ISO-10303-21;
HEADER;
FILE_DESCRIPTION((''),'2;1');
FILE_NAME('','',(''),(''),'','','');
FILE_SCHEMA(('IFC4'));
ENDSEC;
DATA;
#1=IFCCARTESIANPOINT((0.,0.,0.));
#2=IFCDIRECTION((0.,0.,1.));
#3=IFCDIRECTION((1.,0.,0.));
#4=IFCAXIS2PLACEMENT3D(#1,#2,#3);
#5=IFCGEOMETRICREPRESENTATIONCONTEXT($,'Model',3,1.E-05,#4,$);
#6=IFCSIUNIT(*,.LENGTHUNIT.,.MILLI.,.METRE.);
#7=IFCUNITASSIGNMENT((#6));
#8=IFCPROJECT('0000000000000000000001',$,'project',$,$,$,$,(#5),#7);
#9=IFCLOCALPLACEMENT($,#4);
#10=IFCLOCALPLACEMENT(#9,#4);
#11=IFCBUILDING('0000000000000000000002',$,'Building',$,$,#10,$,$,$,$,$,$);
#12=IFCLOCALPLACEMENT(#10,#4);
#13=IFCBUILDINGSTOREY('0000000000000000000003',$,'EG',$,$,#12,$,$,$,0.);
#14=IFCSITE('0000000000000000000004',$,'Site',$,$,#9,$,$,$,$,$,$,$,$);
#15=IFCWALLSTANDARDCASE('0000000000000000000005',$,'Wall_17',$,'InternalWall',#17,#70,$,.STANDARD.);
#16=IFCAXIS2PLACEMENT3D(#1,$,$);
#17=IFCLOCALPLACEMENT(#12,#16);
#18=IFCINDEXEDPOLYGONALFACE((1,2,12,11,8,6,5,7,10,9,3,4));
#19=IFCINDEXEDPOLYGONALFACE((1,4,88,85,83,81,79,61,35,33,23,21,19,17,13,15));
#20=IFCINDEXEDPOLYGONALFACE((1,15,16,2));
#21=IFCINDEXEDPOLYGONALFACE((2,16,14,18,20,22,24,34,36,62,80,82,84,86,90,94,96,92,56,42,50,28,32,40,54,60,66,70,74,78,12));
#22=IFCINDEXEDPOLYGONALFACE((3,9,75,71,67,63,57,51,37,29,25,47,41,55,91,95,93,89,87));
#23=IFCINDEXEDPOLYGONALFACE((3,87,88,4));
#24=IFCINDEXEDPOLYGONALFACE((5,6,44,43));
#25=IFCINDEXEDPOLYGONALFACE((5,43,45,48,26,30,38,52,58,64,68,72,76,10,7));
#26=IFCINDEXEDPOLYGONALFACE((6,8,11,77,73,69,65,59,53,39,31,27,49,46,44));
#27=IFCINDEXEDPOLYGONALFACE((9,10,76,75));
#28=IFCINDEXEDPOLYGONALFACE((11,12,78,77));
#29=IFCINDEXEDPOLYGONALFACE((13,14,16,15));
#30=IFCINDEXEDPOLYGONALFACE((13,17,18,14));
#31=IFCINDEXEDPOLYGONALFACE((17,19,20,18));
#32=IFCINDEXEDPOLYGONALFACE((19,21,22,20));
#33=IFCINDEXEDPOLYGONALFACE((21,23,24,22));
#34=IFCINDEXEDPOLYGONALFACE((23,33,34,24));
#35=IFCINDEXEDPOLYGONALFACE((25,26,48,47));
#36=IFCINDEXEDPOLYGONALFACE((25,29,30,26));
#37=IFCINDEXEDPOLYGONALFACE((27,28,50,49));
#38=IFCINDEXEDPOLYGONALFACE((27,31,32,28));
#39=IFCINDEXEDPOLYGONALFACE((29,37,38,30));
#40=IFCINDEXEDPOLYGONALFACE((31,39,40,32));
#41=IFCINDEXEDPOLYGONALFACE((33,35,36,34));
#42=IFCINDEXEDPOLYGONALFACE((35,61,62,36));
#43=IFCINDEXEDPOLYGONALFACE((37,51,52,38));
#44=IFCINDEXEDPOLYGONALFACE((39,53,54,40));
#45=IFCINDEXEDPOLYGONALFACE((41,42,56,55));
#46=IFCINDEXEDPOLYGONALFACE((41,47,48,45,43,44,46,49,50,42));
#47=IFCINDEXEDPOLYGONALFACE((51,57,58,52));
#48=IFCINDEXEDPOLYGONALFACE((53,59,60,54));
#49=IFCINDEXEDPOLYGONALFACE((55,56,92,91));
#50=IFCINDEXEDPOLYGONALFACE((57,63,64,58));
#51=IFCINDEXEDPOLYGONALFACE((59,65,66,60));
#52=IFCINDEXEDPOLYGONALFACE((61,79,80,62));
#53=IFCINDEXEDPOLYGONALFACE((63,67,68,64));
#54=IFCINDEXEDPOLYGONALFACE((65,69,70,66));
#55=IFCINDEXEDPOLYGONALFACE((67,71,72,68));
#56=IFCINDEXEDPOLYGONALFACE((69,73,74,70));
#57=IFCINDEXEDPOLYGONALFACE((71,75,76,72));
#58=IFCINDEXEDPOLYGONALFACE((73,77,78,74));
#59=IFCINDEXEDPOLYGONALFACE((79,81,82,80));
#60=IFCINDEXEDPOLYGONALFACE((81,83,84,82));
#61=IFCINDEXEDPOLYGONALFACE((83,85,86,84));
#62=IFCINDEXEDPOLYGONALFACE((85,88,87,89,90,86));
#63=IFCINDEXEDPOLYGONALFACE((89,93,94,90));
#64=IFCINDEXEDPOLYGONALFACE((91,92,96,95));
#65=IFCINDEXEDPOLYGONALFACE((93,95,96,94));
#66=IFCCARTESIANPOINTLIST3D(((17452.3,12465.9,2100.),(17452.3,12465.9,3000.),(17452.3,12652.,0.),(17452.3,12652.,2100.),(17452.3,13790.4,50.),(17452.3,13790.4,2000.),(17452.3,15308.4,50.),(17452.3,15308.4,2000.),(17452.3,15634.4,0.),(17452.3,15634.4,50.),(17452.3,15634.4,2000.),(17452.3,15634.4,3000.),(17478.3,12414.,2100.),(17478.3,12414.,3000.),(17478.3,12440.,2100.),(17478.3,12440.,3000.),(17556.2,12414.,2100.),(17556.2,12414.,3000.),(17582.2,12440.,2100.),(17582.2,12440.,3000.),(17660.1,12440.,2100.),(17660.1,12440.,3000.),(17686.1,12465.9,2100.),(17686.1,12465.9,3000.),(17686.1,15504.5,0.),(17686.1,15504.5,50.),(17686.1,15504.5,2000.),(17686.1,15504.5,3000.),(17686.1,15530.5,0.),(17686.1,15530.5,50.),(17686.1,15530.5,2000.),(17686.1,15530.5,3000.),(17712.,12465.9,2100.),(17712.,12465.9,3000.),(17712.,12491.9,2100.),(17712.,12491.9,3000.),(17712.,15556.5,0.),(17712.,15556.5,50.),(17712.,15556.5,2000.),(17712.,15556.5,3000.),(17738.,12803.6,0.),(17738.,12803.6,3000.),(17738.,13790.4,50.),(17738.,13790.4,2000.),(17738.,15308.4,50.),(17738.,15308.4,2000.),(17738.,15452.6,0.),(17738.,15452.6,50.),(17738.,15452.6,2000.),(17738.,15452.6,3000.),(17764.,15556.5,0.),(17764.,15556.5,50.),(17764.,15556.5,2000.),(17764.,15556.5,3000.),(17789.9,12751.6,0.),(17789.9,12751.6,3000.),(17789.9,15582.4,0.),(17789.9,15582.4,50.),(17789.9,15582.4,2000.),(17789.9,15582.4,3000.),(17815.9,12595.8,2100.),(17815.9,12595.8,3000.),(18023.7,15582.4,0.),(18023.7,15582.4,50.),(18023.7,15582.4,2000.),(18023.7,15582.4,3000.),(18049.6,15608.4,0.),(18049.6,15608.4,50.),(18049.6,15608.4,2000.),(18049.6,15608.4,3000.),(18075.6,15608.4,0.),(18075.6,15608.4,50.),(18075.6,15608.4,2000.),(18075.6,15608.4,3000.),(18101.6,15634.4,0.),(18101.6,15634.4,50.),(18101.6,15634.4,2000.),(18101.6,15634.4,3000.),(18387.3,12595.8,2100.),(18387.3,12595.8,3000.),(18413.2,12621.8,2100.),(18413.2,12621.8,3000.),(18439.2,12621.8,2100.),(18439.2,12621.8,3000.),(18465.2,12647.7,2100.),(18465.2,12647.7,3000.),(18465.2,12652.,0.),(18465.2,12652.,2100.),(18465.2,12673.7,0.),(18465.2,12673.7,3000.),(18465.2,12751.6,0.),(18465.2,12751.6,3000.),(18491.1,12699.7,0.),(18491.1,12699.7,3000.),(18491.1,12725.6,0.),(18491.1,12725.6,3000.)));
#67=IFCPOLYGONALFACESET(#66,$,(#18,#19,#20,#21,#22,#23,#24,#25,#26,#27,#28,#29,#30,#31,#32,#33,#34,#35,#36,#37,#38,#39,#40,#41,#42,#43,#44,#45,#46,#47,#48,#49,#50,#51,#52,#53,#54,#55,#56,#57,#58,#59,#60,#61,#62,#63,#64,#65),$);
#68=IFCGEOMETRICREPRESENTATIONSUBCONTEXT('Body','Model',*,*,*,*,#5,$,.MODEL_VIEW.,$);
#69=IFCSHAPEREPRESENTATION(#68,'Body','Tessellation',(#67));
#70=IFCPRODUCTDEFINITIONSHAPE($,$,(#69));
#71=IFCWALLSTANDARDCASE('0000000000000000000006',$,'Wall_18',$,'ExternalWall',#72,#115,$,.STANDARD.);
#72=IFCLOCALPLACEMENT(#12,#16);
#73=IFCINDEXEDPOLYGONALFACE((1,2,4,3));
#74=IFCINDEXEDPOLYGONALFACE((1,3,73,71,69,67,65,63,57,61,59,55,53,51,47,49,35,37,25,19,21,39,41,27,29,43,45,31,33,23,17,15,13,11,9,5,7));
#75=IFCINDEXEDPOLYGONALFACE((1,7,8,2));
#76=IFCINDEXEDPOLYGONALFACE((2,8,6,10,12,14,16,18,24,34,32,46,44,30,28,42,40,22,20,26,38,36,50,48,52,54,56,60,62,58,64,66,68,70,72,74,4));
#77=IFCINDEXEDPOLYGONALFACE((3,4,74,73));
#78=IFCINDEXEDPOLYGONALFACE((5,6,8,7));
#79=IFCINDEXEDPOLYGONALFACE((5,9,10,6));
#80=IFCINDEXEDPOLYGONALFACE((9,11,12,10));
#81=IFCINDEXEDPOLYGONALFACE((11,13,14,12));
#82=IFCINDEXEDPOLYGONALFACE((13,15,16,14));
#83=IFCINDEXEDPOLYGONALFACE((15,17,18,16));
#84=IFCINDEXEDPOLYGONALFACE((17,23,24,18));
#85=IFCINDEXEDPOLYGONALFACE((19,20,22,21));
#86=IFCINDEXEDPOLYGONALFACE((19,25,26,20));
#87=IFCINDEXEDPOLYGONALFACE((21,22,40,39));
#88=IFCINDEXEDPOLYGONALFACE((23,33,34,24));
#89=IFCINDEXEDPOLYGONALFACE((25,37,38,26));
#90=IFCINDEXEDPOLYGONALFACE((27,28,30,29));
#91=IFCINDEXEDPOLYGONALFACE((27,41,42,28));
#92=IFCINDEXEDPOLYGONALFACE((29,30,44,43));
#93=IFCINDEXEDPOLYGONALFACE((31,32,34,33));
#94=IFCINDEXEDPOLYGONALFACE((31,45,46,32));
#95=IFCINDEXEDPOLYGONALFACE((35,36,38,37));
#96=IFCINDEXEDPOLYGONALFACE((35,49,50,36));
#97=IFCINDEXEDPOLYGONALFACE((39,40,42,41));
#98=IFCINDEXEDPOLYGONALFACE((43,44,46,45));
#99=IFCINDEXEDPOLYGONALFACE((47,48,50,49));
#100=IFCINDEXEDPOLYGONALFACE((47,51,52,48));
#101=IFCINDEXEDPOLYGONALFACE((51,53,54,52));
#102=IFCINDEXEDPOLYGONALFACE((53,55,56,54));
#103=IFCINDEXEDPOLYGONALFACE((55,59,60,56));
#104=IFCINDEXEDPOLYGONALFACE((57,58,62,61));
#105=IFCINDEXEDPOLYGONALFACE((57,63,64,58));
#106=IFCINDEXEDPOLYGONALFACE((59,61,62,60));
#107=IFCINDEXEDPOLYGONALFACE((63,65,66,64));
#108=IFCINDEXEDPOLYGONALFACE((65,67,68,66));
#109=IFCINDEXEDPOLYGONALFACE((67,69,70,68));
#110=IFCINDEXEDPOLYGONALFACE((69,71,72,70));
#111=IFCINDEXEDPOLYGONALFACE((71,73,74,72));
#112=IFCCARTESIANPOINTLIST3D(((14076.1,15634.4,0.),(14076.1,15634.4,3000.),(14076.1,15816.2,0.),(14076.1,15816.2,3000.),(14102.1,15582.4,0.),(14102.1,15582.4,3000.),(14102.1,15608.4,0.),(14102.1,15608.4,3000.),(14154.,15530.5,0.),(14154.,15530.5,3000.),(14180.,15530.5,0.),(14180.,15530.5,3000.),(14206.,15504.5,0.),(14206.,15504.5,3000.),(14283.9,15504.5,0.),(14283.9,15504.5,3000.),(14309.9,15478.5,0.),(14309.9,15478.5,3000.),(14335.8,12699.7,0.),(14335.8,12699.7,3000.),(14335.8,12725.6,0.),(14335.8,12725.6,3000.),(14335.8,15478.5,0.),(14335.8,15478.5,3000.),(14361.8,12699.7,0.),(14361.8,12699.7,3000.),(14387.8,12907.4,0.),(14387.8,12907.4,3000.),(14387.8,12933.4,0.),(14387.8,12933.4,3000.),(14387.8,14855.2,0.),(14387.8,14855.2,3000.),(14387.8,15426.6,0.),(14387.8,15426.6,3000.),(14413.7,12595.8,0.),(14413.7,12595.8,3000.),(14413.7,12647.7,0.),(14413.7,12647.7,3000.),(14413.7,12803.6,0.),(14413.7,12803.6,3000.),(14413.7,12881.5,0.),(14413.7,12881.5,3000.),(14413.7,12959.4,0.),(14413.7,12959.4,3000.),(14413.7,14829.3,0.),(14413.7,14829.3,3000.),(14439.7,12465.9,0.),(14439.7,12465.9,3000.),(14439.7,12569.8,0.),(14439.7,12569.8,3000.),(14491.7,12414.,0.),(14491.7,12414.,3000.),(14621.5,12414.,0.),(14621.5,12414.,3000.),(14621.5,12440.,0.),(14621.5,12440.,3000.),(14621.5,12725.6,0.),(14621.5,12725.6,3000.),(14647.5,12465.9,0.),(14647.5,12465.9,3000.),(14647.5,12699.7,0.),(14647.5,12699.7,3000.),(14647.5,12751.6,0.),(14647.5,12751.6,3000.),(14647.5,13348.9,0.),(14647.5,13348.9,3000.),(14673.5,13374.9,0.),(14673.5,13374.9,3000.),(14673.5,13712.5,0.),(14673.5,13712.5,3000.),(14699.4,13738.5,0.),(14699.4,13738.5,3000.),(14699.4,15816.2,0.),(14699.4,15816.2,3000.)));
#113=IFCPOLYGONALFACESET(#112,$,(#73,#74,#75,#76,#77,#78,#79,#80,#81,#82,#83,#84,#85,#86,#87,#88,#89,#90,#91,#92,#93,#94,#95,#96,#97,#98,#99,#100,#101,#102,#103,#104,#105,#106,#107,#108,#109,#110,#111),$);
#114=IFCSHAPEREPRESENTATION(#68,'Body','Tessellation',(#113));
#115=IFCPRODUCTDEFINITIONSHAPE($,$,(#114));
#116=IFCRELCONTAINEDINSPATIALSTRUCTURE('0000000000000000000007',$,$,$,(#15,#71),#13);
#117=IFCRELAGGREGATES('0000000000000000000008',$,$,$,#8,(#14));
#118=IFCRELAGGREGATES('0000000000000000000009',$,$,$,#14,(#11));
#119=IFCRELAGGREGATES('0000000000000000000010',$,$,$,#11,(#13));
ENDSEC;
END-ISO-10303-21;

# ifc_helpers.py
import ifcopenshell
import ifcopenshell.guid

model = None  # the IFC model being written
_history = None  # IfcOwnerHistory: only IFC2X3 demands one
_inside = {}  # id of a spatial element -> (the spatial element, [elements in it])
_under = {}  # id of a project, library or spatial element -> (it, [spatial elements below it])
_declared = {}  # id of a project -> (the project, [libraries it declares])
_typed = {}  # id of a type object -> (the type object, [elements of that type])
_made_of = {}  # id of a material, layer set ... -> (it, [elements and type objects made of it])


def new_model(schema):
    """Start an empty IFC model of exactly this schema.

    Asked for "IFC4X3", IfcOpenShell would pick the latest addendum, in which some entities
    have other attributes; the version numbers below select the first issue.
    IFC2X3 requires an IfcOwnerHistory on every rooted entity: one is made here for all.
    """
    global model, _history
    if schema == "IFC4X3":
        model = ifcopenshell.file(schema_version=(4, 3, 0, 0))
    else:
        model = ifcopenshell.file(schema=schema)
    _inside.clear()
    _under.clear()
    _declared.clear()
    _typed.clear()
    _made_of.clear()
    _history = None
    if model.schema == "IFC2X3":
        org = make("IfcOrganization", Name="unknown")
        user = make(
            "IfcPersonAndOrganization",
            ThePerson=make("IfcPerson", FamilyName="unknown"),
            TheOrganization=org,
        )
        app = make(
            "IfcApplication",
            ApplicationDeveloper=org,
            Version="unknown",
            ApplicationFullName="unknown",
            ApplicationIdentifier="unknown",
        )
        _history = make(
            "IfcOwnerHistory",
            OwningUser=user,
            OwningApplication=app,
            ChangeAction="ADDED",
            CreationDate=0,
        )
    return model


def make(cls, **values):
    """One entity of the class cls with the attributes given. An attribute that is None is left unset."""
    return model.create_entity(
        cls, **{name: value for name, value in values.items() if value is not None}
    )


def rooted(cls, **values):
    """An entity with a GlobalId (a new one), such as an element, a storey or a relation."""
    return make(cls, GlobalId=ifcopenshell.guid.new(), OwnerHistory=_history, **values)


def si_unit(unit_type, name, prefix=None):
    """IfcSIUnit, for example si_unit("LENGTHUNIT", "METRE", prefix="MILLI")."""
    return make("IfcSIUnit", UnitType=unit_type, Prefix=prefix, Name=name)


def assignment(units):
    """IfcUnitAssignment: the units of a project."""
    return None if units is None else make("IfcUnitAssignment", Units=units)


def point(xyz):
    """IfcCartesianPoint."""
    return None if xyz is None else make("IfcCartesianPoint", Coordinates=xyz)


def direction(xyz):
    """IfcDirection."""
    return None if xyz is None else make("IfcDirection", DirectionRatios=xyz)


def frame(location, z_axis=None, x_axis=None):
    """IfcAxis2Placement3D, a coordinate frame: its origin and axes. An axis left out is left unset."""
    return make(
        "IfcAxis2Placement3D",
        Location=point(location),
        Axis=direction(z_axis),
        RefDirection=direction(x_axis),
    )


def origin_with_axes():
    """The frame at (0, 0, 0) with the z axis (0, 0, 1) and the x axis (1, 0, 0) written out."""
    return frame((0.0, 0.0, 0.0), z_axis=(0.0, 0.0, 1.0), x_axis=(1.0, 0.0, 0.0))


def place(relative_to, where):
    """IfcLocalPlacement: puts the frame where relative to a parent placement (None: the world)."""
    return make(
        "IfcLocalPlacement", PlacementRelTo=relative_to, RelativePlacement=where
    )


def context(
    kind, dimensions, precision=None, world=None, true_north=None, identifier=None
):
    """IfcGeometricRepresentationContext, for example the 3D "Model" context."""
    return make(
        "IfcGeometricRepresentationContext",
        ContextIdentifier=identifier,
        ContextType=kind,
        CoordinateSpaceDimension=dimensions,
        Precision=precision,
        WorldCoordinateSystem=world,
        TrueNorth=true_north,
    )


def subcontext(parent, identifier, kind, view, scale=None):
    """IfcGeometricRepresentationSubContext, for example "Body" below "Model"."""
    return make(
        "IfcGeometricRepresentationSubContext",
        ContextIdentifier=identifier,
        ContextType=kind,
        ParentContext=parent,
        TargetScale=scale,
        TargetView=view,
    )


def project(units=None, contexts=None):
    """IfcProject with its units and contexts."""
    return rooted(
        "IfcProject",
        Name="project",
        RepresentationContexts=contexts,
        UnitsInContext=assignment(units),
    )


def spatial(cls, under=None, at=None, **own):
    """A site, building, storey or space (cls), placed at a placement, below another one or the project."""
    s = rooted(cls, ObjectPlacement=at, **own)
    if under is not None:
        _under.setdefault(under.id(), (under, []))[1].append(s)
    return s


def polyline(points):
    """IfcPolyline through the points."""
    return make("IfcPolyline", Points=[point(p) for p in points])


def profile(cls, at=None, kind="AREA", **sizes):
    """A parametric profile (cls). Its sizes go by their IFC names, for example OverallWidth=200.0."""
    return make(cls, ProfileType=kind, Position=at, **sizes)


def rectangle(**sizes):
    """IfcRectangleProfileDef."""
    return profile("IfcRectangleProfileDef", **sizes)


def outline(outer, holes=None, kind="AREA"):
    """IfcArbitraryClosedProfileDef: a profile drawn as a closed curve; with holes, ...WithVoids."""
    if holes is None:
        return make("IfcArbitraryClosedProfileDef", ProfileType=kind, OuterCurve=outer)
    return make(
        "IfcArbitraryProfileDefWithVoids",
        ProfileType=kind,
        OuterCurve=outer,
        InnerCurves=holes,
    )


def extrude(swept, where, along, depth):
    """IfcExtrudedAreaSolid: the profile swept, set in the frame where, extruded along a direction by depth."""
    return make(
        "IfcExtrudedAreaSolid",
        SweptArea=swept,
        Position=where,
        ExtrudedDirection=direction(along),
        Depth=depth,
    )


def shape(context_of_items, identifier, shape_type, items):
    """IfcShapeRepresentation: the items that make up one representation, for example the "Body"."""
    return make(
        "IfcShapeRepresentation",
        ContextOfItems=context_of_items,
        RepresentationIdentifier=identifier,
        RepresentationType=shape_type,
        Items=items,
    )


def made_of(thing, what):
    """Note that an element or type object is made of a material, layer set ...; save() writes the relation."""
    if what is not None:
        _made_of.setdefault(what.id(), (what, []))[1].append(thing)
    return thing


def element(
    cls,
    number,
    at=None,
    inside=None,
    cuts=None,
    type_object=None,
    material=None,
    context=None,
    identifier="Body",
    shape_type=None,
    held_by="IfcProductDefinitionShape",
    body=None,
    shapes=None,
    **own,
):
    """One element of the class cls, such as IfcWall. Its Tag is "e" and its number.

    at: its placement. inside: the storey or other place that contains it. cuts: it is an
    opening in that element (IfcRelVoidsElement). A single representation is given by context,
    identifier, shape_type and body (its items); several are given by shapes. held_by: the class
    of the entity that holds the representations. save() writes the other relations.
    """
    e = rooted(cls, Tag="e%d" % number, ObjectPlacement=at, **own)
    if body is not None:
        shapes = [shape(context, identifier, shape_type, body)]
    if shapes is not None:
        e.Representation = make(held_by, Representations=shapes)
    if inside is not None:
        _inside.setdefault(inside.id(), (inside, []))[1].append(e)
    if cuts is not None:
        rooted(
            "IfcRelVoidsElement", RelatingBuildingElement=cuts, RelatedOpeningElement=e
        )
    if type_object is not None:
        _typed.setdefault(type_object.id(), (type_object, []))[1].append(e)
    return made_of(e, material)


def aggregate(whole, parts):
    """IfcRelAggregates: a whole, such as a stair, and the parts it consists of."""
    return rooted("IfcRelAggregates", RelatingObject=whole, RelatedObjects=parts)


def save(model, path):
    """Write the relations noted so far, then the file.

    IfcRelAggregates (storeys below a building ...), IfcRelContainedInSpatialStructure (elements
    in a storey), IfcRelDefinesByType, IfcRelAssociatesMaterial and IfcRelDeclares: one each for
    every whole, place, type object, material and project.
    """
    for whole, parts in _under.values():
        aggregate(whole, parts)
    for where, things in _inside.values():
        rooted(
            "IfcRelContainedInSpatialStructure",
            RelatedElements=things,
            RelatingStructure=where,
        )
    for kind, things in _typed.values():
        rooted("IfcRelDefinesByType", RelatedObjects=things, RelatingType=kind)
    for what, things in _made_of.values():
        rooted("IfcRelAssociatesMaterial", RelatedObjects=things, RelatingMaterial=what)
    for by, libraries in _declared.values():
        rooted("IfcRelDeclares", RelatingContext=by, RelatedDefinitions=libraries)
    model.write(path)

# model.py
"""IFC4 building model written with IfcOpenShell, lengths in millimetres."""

from ifc_helpers import new_model, si_unit, frame, origin_with_axes, place, context, subcontext, project, spatial, polyline, rectangle, outline, extrude, element, save


model = new_model("IFC4")

# Units and contexts
model_context = context("Model", 3, precision=1e-05, world=origin_with_axes())
body_context = subcontext(model_context, "Body", "Model", "MODEL_VIEW")
ifc_project = project(units=[si_unit("LENGTHUNIT", "METRE", prefix="MILLI")], contexts=[model_context])

# Site, building, storey
site_placement = place(None, origin_with_axes())
site = spatial("IfcSite", under=ifc_project, at=site_placement, Name="Site")
building_placement = place(site_placement, origin_with_axes())
building = spatial("IfcBuilding", under=site, at=building_placement, Name="Building")
storey_placement = place(building_placement, origin_with_axes())
storey = spatial("IfcBuildingStorey", under=building, at=storey_placement, Name="EG", Elevation=0.0)

# Wall, openings
wall_1_placement = place(storey_placement, origin_with_axes())
wall_1 = element("IfcWallStandardCase", 1, at=wall_1_placement, inside=storey, Name="Wall_17", ObjectType="InternalWall", PredefinedType="STANDARD", context=body_context, shape_type="SweptSolid", body=[
    extrude(outline(polyline([(17478.3, 12414.0, 0.0), (17478.3, 12440.0, 0.0), (17452.3, 12465.9, 0.0), (17452.3, 15634.4, 0.0), (18101.6, 15634.4, 0.0), (18075.6, 15608.4, 0.0), (18049.6, 15608.4, 0.0), (18023.7, 15582.4, 0.0), (17789.9, 15582.4, 0.0), (17764.0, 15556.5, 0.0), (17712.0, 15556.5, 0.0), (17686.1, 15530.5, 0.0), (17686.1, 15504.5, 0.0), (17738.0, 15452.6, 0.0), (17738.0, 12803.6, 0.0), (17789.9, 12751.6, 0.0), (18465.2, 12751.6, 0.0), (18491.1, 12725.6, 0.0), (18491.1, 12699.7, 0.0), (18465.2, 12673.7, 0.0), (18465.2, 12647.7, 0.0), (18439.2, 12621.8, 0.0), (18413.2, 12621.8, 0.0), (18387.3, 12595.8, 0.0), (17815.9, 12595.8, 0.0), (17712.0, 12491.9, 0.0), (17712.0, 12465.9, 0.0), (17686.1, 12465.9, 0.0), (17660.1, 12440.0, 0.0), (17582.2, 12440.0, 0.0), (17556.2, 12414.0, 0.0), (17478.3, 12414.0, 0.0)])), origin_with_axes(), (0.0, 0.0, 1.0), 3000.0),
])
opening_1_placement = place(wall_1_placement, origin_with_axes())
element("IfcOpeningElement", 2, at=opening_1_placement, inside=storey, cuts=wall_1, context=body_context, shape_type="SweptSolid", body=[
    extrude(rectangle(XDim=450.0, YDim=1038.8), frame((17971.7, 12427.0, 0.0), z_axis=(0.0, 0.0, 1.0), x_axis=(0.0, 1.0, 0.0)), (0.0, 0.0, 1.0), 2100.0),
])
opening_2_placement = place(wall_1_placement, origin_with_axes())
element("IfcOpeningElement", 3, at=opening_2_placement, inside=storey, cuts=wall_1, context=body_context, shape_type="SweptSolid", body=[
    extrude(rectangle(XDim=600.0, YDim=1038.8), frame((17971.7, 15608.4, 50.0), z_axis=(0.0, 0.0, 1.0), x_axis=(0.0, 1.0, 0.0)), (0.0, 0.0, 1.0), 1950.0),
])
opening_3_placement = place(wall_1_placement, origin_with_axes())
element("IfcOpeningElement", 4, at=opening_3_placement, inside=storey, cuts=wall_1, context=body_context, shape_type="SweptSolid", body=[
    extrude(rectangle(XDim=1843.9, YDim=1038.8), frame((17971.7, 14712.4, 50.0), z_axis=(0.0, 0.0, 1.0), x_axis=(0.0, 1.0, 0.0)), (0.0, 0.0, 1.0), 1950.0),
])

# Wall, opening
wall_2_placement = place(storey_placement, origin_with_axes())
wall_2 = element("IfcWallStandardCase", 5, at=wall_2_placement, inside=storey, Name="Wall_18", ObjectType="ExternalWall", PredefinedType="STANDARD", context=body_context, shape_type="SweptSolid", body=[
    extrude(outline(polyline([(14491.7, 12414.0, 0.0), (14439.7, 12465.9, 0.0), (14439.7, 12569.8, 0.0), (14413.7, 12595.8, 0.0), (14413.7, 12647.7, 0.0), (14361.8, 12699.7, 0.0), (14335.8, 12699.7, 0.0), (14335.8, 12725.6, 0.0), (14413.7, 12803.6, 0.0), (14413.7, 12881.5, 0.0), (14387.8, 12907.4, 0.0), (14387.8, 12933.4, 0.0), (14413.7, 12959.4, 0.0), (14413.7, 14829.3, 0.0), (14387.8, 14855.2, 0.0), (14387.8, 15426.6, 0.0), (14335.8, 15478.5, 0.0), (14309.9, 15478.5, 0.0), (14283.9, 15504.5, 0.0), (14206.0, 15504.5, 0.0), (14180.0, 15530.5, 0.0), (14154.0, 15530.5, 0.0), (14102.1, 15582.4, 0.0), (14102.1, 15608.4, 0.0), (14076.1, 15634.4, 0.0), (14076.1, 15816.2, 0.0), (14699.4, 15816.2, 0.0), (14699.4, 13738.5, 0.0), (14673.5, 13712.5, 0.0), (14673.5, 13374.9, 0.0), (14647.5, 13348.9, 0.0), (14647.5, 12751.6, 0.0), (14621.5, 12725.6, 0.0), (14647.5, 12699.7, 0.0), (14647.5, 12465.9, 0.0), (14621.5, 12440.0, 0.0), (14621.5, 12414.0, 0.0), (14491.7, 12414.0, 0.0)])), origin_with_axes(), (0.0, 0.0, 1.0), 3000.0),
])
opening_4_placement = place(wall_2_placement, origin_with_axes())
element("IfcOpeningElement", 6, at=opening_4_placement, inside=storey, cuts=wall_2, context=body_context, shape_type="SweptSolid", body=[
    extrude(rectangle(XDim=900.0, YDim=623.3), frame((14262.5, 11949.6, 0.0), z_axis=(0.0, 0.0, 1.0), x_axis=(0.0, -1.0, 0.0)), (0.0, 0.0, 1.0), 2100.0),
])

save(model, "model.ifc")
